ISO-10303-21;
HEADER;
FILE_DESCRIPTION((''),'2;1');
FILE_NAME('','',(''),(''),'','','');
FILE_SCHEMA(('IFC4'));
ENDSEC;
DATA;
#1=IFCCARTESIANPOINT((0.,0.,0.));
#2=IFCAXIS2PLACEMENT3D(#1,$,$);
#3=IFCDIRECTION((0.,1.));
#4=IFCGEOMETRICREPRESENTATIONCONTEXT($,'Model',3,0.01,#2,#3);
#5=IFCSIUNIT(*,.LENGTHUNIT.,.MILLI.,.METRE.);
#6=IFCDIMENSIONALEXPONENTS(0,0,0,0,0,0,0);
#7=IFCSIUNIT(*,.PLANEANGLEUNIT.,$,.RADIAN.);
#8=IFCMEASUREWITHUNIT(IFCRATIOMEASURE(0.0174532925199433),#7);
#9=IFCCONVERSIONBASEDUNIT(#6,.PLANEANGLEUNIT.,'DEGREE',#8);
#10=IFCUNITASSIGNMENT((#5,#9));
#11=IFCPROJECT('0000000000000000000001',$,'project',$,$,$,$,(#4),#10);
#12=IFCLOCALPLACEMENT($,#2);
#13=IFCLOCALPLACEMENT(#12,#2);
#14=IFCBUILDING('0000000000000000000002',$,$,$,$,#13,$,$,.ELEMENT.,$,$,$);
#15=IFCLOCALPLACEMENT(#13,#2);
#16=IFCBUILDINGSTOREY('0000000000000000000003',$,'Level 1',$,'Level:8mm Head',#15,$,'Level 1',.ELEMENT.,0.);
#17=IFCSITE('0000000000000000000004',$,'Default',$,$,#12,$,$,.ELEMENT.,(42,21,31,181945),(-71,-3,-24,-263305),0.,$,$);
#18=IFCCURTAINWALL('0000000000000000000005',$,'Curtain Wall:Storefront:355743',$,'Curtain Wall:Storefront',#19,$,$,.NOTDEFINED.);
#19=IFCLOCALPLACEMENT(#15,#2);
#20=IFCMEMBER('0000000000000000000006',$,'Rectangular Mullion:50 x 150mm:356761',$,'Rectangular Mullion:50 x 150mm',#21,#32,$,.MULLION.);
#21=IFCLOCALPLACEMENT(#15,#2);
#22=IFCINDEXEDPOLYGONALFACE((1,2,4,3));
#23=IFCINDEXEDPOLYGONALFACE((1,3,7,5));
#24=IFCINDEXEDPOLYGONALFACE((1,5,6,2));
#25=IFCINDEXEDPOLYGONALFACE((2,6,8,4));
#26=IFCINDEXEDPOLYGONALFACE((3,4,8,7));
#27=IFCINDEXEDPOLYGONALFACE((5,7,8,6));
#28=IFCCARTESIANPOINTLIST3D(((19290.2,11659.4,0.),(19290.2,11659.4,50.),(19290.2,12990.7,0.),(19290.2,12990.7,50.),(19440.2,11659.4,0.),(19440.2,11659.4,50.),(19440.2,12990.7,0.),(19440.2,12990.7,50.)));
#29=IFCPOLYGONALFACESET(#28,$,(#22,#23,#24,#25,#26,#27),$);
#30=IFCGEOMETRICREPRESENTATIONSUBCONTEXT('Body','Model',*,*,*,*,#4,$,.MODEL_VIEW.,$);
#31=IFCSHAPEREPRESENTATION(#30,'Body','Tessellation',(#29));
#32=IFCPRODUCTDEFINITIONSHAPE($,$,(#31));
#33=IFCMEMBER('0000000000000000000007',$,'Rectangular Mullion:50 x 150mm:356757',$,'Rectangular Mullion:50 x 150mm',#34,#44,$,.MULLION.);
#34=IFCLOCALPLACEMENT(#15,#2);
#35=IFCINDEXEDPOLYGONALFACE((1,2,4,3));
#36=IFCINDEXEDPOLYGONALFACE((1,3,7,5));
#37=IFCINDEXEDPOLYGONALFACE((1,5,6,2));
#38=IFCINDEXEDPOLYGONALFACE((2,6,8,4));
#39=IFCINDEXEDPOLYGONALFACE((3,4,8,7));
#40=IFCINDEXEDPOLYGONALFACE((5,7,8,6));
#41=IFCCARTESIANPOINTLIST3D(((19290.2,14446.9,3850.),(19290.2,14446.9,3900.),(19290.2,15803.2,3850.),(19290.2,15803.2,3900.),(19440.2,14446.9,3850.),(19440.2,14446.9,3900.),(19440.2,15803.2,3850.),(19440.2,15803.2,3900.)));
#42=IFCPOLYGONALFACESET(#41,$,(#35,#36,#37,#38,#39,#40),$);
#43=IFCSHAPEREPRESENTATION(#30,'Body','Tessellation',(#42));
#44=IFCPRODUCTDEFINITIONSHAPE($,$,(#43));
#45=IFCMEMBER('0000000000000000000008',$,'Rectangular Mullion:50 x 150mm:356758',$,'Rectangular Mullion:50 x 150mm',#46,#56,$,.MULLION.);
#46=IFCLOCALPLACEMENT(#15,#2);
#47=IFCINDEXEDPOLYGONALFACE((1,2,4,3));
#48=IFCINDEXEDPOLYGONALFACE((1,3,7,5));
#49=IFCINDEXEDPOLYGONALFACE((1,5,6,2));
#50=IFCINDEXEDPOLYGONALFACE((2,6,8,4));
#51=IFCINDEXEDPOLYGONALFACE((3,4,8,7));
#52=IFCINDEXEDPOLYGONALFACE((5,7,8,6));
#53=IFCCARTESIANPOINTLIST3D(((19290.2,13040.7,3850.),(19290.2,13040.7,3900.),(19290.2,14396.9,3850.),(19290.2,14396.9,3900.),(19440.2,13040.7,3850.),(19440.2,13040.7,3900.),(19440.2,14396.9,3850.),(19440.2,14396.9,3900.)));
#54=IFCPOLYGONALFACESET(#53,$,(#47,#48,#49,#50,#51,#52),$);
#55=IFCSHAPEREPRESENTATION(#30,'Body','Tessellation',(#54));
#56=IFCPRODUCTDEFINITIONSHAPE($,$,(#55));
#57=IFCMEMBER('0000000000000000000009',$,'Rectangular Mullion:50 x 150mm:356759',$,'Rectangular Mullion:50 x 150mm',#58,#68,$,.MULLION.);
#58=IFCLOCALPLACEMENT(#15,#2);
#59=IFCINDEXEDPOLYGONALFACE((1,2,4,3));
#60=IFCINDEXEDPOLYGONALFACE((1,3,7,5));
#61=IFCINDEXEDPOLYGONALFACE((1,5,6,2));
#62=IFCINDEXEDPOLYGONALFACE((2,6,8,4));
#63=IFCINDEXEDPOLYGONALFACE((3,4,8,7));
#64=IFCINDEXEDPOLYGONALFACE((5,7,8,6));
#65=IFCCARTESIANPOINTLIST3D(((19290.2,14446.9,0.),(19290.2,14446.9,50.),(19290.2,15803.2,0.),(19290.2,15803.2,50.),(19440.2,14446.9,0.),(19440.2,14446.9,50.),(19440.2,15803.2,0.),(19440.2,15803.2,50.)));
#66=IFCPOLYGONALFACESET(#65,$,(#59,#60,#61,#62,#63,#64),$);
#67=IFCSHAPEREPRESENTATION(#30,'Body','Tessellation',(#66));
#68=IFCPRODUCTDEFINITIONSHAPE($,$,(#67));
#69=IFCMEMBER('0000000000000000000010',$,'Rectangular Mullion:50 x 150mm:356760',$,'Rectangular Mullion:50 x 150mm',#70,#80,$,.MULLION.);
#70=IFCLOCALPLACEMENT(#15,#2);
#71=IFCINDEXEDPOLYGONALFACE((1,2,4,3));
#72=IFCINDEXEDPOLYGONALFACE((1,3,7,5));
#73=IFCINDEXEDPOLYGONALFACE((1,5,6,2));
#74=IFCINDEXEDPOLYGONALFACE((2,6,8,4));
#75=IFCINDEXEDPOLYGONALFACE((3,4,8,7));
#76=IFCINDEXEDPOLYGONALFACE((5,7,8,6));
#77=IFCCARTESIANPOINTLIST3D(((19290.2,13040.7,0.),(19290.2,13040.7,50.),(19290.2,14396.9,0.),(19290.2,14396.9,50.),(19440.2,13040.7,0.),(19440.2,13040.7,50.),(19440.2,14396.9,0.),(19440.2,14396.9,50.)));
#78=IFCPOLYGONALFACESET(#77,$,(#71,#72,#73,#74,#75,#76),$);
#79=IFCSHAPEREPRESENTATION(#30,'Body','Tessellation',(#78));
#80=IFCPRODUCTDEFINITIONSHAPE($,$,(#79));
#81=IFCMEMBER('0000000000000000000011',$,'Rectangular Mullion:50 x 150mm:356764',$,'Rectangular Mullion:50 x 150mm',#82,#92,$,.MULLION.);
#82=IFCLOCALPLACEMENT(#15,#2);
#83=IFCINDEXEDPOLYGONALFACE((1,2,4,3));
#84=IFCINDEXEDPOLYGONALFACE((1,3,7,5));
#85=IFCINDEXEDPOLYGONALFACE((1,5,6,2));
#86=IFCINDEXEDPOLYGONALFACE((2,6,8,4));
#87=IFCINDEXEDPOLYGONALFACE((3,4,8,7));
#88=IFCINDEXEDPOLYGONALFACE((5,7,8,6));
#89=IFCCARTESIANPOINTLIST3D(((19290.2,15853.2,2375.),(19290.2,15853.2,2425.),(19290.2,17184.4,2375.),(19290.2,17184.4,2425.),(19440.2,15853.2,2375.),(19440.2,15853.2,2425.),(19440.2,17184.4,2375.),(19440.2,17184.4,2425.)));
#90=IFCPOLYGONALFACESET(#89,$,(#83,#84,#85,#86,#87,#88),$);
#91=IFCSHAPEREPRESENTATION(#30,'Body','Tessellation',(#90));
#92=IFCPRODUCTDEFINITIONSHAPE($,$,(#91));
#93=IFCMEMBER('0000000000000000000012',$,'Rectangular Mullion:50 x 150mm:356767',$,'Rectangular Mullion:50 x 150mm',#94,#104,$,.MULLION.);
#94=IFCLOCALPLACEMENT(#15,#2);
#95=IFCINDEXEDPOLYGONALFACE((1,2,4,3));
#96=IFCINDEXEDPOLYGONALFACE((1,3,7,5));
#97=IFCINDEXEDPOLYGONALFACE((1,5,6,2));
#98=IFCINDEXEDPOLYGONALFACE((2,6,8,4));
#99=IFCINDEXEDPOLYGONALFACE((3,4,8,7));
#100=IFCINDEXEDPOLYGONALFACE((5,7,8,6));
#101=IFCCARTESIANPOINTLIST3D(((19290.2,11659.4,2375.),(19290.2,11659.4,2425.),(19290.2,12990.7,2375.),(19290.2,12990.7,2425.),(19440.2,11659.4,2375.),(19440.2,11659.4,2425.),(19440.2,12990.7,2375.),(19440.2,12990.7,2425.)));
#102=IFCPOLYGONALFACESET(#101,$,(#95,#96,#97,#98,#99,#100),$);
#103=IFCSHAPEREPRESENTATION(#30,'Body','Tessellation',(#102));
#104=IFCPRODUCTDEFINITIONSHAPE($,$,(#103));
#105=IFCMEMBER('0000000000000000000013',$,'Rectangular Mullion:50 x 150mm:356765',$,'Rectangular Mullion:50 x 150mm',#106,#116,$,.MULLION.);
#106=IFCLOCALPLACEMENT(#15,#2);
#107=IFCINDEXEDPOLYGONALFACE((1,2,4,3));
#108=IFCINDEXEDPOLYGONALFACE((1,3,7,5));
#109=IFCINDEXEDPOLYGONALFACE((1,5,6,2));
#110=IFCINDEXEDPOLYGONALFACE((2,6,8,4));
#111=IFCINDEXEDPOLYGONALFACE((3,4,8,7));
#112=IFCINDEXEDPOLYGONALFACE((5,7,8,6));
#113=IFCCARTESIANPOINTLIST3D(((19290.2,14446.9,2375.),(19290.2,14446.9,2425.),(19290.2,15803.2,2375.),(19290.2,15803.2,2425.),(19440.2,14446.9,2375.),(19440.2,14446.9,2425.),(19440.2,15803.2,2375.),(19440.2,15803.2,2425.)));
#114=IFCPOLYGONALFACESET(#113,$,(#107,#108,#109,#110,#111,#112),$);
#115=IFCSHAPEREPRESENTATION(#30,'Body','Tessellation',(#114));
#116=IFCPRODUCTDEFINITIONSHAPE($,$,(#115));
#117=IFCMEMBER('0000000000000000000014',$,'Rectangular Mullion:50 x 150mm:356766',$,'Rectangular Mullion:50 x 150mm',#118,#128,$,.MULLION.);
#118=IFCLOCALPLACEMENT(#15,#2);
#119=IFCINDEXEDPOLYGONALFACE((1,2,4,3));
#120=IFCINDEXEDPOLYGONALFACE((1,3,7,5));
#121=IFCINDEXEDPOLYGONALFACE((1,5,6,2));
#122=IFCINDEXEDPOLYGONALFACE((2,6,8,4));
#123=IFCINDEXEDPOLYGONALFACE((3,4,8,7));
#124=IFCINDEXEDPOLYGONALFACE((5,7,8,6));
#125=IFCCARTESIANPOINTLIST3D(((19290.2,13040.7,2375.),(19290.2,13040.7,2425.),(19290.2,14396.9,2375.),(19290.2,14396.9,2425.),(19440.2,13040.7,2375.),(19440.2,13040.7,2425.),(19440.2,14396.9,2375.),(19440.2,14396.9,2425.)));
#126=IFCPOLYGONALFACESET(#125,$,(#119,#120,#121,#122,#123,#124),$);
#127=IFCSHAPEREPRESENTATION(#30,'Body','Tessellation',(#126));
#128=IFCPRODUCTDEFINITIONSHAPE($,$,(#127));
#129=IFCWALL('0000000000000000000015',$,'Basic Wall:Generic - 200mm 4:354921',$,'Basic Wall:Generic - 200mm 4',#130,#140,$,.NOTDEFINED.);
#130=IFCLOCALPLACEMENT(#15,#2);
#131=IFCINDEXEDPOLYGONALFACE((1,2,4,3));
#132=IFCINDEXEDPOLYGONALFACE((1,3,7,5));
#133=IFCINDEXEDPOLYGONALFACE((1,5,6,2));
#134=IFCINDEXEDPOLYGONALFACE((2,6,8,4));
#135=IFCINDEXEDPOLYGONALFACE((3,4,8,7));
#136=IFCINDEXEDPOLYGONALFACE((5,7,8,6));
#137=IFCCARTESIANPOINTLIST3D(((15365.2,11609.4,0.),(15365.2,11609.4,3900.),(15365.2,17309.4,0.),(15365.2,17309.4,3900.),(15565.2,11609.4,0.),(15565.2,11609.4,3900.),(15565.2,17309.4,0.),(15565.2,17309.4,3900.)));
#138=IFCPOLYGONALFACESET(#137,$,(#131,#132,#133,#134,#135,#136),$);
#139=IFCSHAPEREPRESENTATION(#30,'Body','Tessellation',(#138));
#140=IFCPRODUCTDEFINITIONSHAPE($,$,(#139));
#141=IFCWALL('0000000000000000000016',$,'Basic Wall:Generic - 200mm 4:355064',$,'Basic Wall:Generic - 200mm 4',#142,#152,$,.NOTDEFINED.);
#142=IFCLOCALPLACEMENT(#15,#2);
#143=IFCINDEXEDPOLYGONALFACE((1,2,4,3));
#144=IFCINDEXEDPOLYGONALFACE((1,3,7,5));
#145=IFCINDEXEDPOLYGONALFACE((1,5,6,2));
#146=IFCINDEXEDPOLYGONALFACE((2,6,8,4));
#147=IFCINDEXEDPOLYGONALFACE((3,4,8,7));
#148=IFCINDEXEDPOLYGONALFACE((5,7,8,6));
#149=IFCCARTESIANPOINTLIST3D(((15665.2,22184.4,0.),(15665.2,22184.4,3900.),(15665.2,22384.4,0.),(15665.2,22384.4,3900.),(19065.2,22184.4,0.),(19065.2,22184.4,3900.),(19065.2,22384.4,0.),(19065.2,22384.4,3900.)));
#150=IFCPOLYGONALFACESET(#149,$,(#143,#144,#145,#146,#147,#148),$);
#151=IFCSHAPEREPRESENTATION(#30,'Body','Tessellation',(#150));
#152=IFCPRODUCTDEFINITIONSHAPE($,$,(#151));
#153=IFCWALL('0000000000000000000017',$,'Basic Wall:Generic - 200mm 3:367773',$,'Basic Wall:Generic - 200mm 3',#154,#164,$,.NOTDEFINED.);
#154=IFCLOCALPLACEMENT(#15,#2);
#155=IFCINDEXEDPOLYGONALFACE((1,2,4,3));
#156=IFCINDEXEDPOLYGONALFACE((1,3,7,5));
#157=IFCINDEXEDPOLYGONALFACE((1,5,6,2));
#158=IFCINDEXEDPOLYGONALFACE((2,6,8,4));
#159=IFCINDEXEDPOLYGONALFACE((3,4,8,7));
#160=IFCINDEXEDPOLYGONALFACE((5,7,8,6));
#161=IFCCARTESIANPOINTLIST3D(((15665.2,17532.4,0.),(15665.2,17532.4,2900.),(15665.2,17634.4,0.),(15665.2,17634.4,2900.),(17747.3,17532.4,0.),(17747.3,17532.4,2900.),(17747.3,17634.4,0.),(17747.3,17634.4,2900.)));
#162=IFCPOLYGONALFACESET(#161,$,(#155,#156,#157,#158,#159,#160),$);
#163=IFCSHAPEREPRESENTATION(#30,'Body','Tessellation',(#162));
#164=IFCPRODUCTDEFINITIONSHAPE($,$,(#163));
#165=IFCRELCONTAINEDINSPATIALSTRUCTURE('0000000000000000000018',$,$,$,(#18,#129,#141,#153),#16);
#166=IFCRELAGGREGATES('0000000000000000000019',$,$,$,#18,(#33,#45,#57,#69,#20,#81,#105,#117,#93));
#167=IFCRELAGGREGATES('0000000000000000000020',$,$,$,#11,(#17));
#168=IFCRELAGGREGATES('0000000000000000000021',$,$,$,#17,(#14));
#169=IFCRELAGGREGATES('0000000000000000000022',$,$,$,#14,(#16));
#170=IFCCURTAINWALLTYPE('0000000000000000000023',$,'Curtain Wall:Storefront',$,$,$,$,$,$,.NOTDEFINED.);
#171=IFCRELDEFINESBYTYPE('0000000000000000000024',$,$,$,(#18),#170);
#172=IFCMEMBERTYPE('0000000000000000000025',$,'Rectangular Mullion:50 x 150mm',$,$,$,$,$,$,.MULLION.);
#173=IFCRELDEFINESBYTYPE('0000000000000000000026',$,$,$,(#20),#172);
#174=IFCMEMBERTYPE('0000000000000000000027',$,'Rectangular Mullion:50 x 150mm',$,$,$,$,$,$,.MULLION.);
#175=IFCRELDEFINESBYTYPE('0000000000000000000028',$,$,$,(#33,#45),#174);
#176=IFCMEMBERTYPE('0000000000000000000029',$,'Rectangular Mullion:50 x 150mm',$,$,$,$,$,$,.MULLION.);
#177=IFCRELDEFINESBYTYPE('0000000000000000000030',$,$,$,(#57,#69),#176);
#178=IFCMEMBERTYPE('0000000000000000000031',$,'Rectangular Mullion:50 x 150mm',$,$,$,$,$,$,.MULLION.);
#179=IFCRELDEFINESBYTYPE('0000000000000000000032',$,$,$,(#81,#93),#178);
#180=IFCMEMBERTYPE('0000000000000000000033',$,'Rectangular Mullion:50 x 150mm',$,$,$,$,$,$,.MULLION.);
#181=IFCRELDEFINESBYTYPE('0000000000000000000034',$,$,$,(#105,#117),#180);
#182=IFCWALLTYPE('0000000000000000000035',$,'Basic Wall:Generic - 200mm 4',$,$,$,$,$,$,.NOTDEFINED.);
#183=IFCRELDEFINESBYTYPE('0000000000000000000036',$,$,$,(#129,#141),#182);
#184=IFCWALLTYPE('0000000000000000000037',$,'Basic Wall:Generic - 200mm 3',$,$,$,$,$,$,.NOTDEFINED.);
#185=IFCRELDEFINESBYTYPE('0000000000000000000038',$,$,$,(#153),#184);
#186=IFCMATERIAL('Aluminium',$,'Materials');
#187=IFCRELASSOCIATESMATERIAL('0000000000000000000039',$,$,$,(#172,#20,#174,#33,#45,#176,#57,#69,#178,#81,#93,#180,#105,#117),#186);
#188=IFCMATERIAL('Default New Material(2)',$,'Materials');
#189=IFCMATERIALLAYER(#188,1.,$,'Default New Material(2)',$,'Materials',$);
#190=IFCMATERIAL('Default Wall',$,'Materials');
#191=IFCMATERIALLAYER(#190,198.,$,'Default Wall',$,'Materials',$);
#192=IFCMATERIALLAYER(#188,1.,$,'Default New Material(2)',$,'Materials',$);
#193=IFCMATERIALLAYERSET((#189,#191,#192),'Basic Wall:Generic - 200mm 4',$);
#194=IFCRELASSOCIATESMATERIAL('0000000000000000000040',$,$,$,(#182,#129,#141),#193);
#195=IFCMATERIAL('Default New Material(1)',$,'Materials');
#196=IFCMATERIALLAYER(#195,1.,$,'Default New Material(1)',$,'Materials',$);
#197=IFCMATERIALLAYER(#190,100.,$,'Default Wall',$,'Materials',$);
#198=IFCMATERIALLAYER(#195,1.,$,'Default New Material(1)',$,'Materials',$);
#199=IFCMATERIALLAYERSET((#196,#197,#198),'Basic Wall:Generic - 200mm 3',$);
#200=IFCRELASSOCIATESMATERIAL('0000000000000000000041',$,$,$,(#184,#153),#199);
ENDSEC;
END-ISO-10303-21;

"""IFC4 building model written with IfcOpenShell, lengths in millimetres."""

from ifc_helpers import new_model, entity, si_unit, converted_unit, direction, frame, origin, place, context, subcontext, project, spatial, indexed_curve, outline, extrude, source, transform, mapped, material, layer, layer_set, type_object, type_shapes, element, aggregate, save


model = new_model("IFC4")

# Units and contexts
model_context = context("Model", 3, precision=0.01, world=origin(), true_north=direction((0.0, 1.0)))
body_context = subcontext(model_context, "Body", "Model", "MODEL_VIEW")
ifc_project = project(units=[si_unit("LENGTHUNIT", "METRE", prefix="MILLI"), converted_unit("PLANEANGLEUNIT", "DEGREE", entity("IfcRatioMeasure", 0.0174532925199433), si_unit("PLANEANGLEUNIT", "RADIAN"), dimensions=[0, 0, 0, 0, 0, 0, 0])], contexts=[model_context])

# Site, building, storey
site_placement = place(None, origin())
site = spatial("IfcSite", under=ifc_project, at=site_placement, Name="Default", CompositionType="ELEMENT", RefLatitude=(42, 21, 31, 181945), RefLongitude=(-71, -3, -24, -263305), RefElevation=0.0)
building_placement = place(site_placement, origin())
building = spatial("IfcBuilding", under=site, at=building_placement, CompositionType="ELEMENT")
storey_placement = place(building_placement, origin())
storey = spatial("IfcBuildingStorey", under=building, at=storey_placement, Name="Level 1", ObjectType="Level:8mm Head", LongName="Level 1", CompositionType="ELEMENT", Elevation=0.0)

# Curtain wall, members
curtain_wall_type = type_object("IfcCurtainWallType", Name="Curtain Wall:Storefront", PredefinedType="NOTDEFINED")
curtain_wall_placement = place(storey_placement, origin())
curtain_wall = element("IfcCurtainWall", 1, at=curtain_wall_placement, inside=storey, type_object=curtain_wall_type, Name="Curtain Wall:Storefront:355743", ObjectType="Curtain Wall:Storefront", PredefinedType="NOTDEFINED")
ifc_material_1 = material(Name="Aluminium", Category="Materials")
member_type_1 = type_object("IfcMemberType", Name="Rectangular Mullion:50 x 150mm", PredefinedType="MULLION", material=ifc_material_1)
shared_shape_1 = source(origin(), body_context, "Body", "SweptSolid", [
    extrude(outline(indexed_curve([(-75.0, -25.0), (75.0, -25.0), (75.0, 25.0), (-75.0, 25.0), (-75.0, -25.0)], self_intersect=False)), frame((-25.0, 0.0, -1331.3), z_axis=(0.0, 0.0, 1.0), x_axis=(0.0, -1.0, 0.0)), (0.0, 0.0, 1.0), 1331.3),
])
type_shapes(member_type_1, [shared_shape_1])
member_1_placement = place(storey_placement, frame((19365.2, 12990.7, 0.0), z_axis=(0.0, 1.0, 0.0), x_axis=(0.0, 0.0, -1.0)))
member_1 = element("IfcMember", 2, at=member_1_placement, type_object=member_type_1, material=ifc_material_1, Name="Rectangular Mullion:50 x 150mm:356761", ObjectType="Rectangular Mullion:50 x 150mm", PredefinedType="MULLION", context=body_context, shape_type="MappedRepresentation", body=[
    mapped(shared_shape_1, transform((0.0, 0.0, 0.0), scale=1.0)),
])
member_type_2 = type_object("IfcMemberType", Name="Rectangular Mullion:50 x 150mm", PredefinedType="MULLION", material=ifc_material_1)
shared_shape_2 = source(origin(), body_context, "Body", "SweptSolid", [
    extrude(outline(indexed_curve([(-75.0, -25.0), (75.0, -25.0), (75.0, 25.0), (-75.0, 25.0), (-75.0, -25.0)], self_intersect=False)), frame((-25.0, 0.0, -1356.2), z_axis=(0.0, 0.0, 1.0), x_axis=(0.0, -1.0, 0.0)), (0.0, 0.0, 1.0), 1356.2),
])
type_shapes(member_type_2, [shared_shape_2])
member_2_placement = place(storey_placement, frame((19365.2, 14446.9, 3900.0), z_axis=(0.0, -1.0, 0.0), x_axis=(0.0, 0.0, 1.0)))
member_2 = element("IfcMember", 3, at=member_2_placement, type_object=member_type_2, material=ifc_material_1, Name="Rectangular Mullion:50 x 150mm:356757", ObjectType="Rectangular Mullion:50 x 150mm", PredefinedType="MULLION", context=body_context, shape_type="MappedRepresentation", body=[
    mapped(shared_shape_2, transform((0.0, 0.0, 0.0), scale=1.0)),
])
member_3_placement = place(storey_placement, frame((19365.2, 13040.7, 3900.0), z_axis=(0.0, -1.0, 0.0), x_axis=(0.0, 0.0, 1.0)))
member_3 = element("IfcMember", 4, at=member_3_placement, type_object=member_type_2, material=ifc_material_1, Name="Rectangular Mullion:50 x 150mm:356758", ObjectType="Rectangular Mullion:50 x 150mm", PredefinedType="MULLION", context=body_context, shape_type="MappedRepresentation", body=[
    mapped(shared_shape_2, transform((0.0, 0.0, 0.0), scale=1.0)),
])
member_type_3 = type_object("IfcMemberType", Name="Rectangular Mullion:50 x 150mm", PredefinedType="MULLION", material=ifc_material_1)
shared_shape_3 = source(origin(), body_context, "Body", "SweptSolid", [
    extrude(outline(indexed_curve([(-75.0, -25.0), (75.0, -25.0), (75.0, 25.0), (-75.0, 25.0), (-75.0, -25.0)], self_intersect=False)), frame((-25.0, 0.0, -1356.2), z_axis=(0.0, 0.0, 1.0), x_axis=(0.0, -1.0, 0.0)), (0.0, 0.0, 1.0), 1356.2),
])
type_shapes(member_type_3, [shared_shape_3])
member_4_placement = place(storey_placement, frame((19365.2, 15803.2, 0.0), z_axis=(0.0, 1.0, 0.0), x_axis=(0.0, 0.0, -1.0)))
member_4 = element("IfcMember", 5, at=member_4_placement, type_object=member_type_3, material=ifc_material_1, Name="Rectangular Mullion:50 x 150mm:356759", ObjectType="Rectangular Mullion:50 x 150mm", PredefinedType="MULLION", context=body_context, shape_type="MappedRepresentation", body=[
    mapped(shared_shape_3, transform((0.0, 0.0, 0.0), scale=1.0)),
])
member_5_placement = place(storey_placement, frame((19365.2, 14396.9, 0.0), z_axis=(0.0, 1.0, 0.0), x_axis=(0.0, 0.0, -1.0)))
member_5 = element("IfcMember", 6, at=member_5_placement, type_object=member_type_3, material=ifc_material_1, Name="Rectangular Mullion:50 x 150mm:356760", ObjectType="Rectangular Mullion:50 x 150mm", PredefinedType="MULLION", context=body_context, shape_type="MappedRepresentation", body=[
    mapped(shared_shape_3, transform((0.0, 0.0, 0.0), scale=1.0)),
])
member_type_4 = type_object("IfcMemberType", Name="Rectangular Mullion:50 x 150mm", PredefinedType="MULLION", material=ifc_material_1)
shared_shape_4 = source(origin(), body_context, "Body", "SweptSolid", [
    extrude(outline(indexed_curve([(-75.0, -25.0), (75.0, -25.0), (75.0, 25.0), (-75.0, 25.0), (-75.0, -25.0)], self_intersect=False)), frame((0.0, 0.0, -1331.3), z_axis=(0.0, 0.0, 1.0), x_axis=(0.0, -1.0, 0.0)), (0.0, 0.0, 1.0), 1331.3),
])
type_shapes(member_type_4, [shared_shape_4])
member_6_placement = place(storey_placement, frame((19365.2, 15853.2, 2400.0), z_axis=(0.0, -1.0, 0.0), x_axis=(0.0, 0.0, 1.0)))
member_6 = element("IfcMember", 7, at=member_6_placement, type_object=member_type_4, material=ifc_material_1, Name="Rectangular Mullion:50 x 150mm:356764", ObjectType="Rectangular Mullion:50 x 150mm", PredefinedType="MULLION", context=body_context, shape_type="MappedRepresentation", body=[
    mapped(shared_shape_4, transform((0.0, 0.0, 0.0), scale=1.0)),
])
member_7_placement = place(storey_placement, frame((19365.2, 11659.4, 2400.0), z_axis=(0.0, -1.0, 0.0), x_axis=(0.0, 0.0, 1.0)))
member_7 = element("IfcMember", 8, at=member_7_placement, type_object=member_type_4, material=ifc_material_1, Name="Rectangular Mullion:50 x 150mm:356767", ObjectType="Rectangular Mullion:50 x 150mm", PredefinedType="MULLION", context=body_context, shape_type="MappedRepresentation", body=[
    mapped(shared_shape_4, transform((0.0, 0.0, 0.0), scale=1.0)),
])
member_type_5 = type_object("IfcMemberType", Name="Rectangular Mullion:50 x 150mm", PredefinedType="MULLION", material=ifc_material_1)
shared_shape_5 = source(origin(), body_context, "Body", "SweptSolid", [
    extrude(outline(indexed_curve([(-75.0, -25.0), (75.0, -25.0), (75.0, 25.0), (-75.0, 25.0), (-75.0, -25.0)], self_intersect=False)), frame((0.0, 0.0, -1356.2), z_axis=(0.0, 0.0, 1.0), x_axis=(0.0, -1.0, 0.0)), (0.0, 0.0, 1.0), 1356.2),
])
type_shapes(member_type_5, [shared_shape_5])
member_8_placement = place(storey_placement, frame((19365.2, 14446.9, 2400.0), z_axis=(0.0, -1.0, 0.0), x_axis=(0.0, 0.0, 1.0)))
member_8 = element("IfcMember", 9, at=member_8_placement, type_object=member_type_5, material=ifc_material_1, Name="Rectangular Mullion:50 x 150mm:356765", ObjectType="Rectangular Mullion:50 x 150mm", PredefinedType="MULLION", context=body_context, shape_type="MappedRepresentation", body=[
    mapped(shared_shape_5, transform((0.0, 0.0, 0.0), scale=1.0)),
])
member_9_placement = place(storey_placement, frame((19365.2, 13040.7, 2400.0), z_axis=(0.0, -1.0, 0.0), x_axis=(0.0, 0.0, 1.0)))
member_9 = element("IfcMember", 10, at=member_9_placement, type_object=member_type_5, material=ifc_material_1, Name="Rectangular Mullion:50 x 150mm:356766", ObjectType="Rectangular Mullion:50 x 150mm", PredefinedType="MULLION", context=body_context, shape_type="MappedRepresentation", body=[
    mapped(shared_shape_5, transform((0.0, 0.0, 0.0), scale=1.0)),
])
aggregate(curtain_wall, [member_2, member_3, member_4, member_5, member_1, member_6, member_8, member_9, member_7])

# Walls
ifc_material_2 = material(Name="Default New Material(2)", Category="Materials")
ifc_layer_1 = layer(ifc_material_2, 1.0, Name="Default New Material(2)", Category="Materials")
ifc_material_3 = material(Name="Default Wall", Category="Materials")
ifc_layer_2 = layer(ifc_material_3, 198.0, Name="Default Wall", Category="Materials")
ifc_layer_3 = layer(ifc_material_2, 1.0, Name="Default New Material(2)", Category="Materials")
ifc_layer_set_1 = layer_set([ifc_layer_1, ifc_layer_2, ifc_layer_3], Name="Basic Wall:Generic - 200mm 4")
wall_type_1 = type_object("IfcWallType", Name="Basic Wall:Generic - 200mm 4", PredefinedType="NOTDEFINED", material=ifc_layer_set_1)
wall_1_placement = place(storey_placement, frame((15465.2, 11609.4, 0.0), z_axis=(0.0, 0.0, 1.0), x_axis=(0.0, 1.0, 0.0)))
element("IfcWall", 11, at=wall_1_placement, inside=storey, type_object=wall_type_1, material=ifc_layer_set_1, Name="Basic Wall:Generic - 200mm 4:354921", ObjectType="Basic Wall:Generic - 200mm 4", PredefinedType="NOTDEFINED", context=body_context, shape_type="SweptSolid", body=[
    extrude(outline(indexed_curve([(5700.0, 100.0), (0.0, 100.0), (0.0, -100.0), (5700.0, -100.0), (5700.0, 100.0)], self_intersect=False)), origin(), (0.0, 0.0, 1.0), 3900.0),
])
wall_2_placement = place(storey_placement, frame((15665.2, 22284.4, 0.0)))
element("IfcWall", 12, at=wall_2_placement, inside=storey, type_object=wall_type_1, material=ifc_layer_set_1, Name="Basic Wall:Generic - 200mm 4:355064", ObjectType="Basic Wall:Generic - 200mm 4", PredefinedType="NOTDEFINED", context=body_context, shape_type="SweptSolid", body=[
    extrude(outline(indexed_curve([(3400.0, 100.0), (0.0, 100.0), (0.0, -100.0), (3400.0, -100.0), (3400.0, 100.0)], self_intersect=False)), origin(), (0.0, 0.0, 1.0), 3900.0),
])
ifc_material_4 = material(Name="Default New Material(1)", Category="Materials")
ifc_layer_4 = layer(ifc_material_4, 1.0, Name="Default New Material(1)", Category="Materials")
ifc_layer_5 = layer(ifc_material_3, 100.0, Name="Default Wall", Category="Materials")
ifc_layer_6 = layer(ifc_material_4, 1.0, Name="Default New Material(1)", Category="Materials")
ifc_layer_set_2 = layer_set([ifc_layer_4, ifc_layer_5, ifc_layer_6], Name="Basic Wall:Generic - 200mm 3")
wall_type_2 = type_object("IfcWallType", Name="Basic Wall:Generic - 200mm 3", PredefinedType="NOTDEFINED", material=ifc_layer_set_2)
wall_3_placement = place(storey_placement, frame((15665.2, 17583.4, 0.0)))
element("IfcWall", 13, at=wall_3_placement, inside=storey, type_object=wall_type_2, material=ifc_layer_set_2, Name="Basic Wall:Generic - 200mm 3:367773", ObjectType="Basic Wall:Generic - 200mm 3", PredefinedType="NOTDEFINED", context=body_context, shape_type="SweptSolid", body=[
    extrude(outline(indexed_curve([(2082.1, 51.0), (0.0, 51.0), (0.0, -51.0), (2082.1, -51.0), (2082.1, 51.0)], self_intersect=False)), origin(), (0.0, 0.0, 1.0), 2900.0),
])

save(model, "model.ifc")
